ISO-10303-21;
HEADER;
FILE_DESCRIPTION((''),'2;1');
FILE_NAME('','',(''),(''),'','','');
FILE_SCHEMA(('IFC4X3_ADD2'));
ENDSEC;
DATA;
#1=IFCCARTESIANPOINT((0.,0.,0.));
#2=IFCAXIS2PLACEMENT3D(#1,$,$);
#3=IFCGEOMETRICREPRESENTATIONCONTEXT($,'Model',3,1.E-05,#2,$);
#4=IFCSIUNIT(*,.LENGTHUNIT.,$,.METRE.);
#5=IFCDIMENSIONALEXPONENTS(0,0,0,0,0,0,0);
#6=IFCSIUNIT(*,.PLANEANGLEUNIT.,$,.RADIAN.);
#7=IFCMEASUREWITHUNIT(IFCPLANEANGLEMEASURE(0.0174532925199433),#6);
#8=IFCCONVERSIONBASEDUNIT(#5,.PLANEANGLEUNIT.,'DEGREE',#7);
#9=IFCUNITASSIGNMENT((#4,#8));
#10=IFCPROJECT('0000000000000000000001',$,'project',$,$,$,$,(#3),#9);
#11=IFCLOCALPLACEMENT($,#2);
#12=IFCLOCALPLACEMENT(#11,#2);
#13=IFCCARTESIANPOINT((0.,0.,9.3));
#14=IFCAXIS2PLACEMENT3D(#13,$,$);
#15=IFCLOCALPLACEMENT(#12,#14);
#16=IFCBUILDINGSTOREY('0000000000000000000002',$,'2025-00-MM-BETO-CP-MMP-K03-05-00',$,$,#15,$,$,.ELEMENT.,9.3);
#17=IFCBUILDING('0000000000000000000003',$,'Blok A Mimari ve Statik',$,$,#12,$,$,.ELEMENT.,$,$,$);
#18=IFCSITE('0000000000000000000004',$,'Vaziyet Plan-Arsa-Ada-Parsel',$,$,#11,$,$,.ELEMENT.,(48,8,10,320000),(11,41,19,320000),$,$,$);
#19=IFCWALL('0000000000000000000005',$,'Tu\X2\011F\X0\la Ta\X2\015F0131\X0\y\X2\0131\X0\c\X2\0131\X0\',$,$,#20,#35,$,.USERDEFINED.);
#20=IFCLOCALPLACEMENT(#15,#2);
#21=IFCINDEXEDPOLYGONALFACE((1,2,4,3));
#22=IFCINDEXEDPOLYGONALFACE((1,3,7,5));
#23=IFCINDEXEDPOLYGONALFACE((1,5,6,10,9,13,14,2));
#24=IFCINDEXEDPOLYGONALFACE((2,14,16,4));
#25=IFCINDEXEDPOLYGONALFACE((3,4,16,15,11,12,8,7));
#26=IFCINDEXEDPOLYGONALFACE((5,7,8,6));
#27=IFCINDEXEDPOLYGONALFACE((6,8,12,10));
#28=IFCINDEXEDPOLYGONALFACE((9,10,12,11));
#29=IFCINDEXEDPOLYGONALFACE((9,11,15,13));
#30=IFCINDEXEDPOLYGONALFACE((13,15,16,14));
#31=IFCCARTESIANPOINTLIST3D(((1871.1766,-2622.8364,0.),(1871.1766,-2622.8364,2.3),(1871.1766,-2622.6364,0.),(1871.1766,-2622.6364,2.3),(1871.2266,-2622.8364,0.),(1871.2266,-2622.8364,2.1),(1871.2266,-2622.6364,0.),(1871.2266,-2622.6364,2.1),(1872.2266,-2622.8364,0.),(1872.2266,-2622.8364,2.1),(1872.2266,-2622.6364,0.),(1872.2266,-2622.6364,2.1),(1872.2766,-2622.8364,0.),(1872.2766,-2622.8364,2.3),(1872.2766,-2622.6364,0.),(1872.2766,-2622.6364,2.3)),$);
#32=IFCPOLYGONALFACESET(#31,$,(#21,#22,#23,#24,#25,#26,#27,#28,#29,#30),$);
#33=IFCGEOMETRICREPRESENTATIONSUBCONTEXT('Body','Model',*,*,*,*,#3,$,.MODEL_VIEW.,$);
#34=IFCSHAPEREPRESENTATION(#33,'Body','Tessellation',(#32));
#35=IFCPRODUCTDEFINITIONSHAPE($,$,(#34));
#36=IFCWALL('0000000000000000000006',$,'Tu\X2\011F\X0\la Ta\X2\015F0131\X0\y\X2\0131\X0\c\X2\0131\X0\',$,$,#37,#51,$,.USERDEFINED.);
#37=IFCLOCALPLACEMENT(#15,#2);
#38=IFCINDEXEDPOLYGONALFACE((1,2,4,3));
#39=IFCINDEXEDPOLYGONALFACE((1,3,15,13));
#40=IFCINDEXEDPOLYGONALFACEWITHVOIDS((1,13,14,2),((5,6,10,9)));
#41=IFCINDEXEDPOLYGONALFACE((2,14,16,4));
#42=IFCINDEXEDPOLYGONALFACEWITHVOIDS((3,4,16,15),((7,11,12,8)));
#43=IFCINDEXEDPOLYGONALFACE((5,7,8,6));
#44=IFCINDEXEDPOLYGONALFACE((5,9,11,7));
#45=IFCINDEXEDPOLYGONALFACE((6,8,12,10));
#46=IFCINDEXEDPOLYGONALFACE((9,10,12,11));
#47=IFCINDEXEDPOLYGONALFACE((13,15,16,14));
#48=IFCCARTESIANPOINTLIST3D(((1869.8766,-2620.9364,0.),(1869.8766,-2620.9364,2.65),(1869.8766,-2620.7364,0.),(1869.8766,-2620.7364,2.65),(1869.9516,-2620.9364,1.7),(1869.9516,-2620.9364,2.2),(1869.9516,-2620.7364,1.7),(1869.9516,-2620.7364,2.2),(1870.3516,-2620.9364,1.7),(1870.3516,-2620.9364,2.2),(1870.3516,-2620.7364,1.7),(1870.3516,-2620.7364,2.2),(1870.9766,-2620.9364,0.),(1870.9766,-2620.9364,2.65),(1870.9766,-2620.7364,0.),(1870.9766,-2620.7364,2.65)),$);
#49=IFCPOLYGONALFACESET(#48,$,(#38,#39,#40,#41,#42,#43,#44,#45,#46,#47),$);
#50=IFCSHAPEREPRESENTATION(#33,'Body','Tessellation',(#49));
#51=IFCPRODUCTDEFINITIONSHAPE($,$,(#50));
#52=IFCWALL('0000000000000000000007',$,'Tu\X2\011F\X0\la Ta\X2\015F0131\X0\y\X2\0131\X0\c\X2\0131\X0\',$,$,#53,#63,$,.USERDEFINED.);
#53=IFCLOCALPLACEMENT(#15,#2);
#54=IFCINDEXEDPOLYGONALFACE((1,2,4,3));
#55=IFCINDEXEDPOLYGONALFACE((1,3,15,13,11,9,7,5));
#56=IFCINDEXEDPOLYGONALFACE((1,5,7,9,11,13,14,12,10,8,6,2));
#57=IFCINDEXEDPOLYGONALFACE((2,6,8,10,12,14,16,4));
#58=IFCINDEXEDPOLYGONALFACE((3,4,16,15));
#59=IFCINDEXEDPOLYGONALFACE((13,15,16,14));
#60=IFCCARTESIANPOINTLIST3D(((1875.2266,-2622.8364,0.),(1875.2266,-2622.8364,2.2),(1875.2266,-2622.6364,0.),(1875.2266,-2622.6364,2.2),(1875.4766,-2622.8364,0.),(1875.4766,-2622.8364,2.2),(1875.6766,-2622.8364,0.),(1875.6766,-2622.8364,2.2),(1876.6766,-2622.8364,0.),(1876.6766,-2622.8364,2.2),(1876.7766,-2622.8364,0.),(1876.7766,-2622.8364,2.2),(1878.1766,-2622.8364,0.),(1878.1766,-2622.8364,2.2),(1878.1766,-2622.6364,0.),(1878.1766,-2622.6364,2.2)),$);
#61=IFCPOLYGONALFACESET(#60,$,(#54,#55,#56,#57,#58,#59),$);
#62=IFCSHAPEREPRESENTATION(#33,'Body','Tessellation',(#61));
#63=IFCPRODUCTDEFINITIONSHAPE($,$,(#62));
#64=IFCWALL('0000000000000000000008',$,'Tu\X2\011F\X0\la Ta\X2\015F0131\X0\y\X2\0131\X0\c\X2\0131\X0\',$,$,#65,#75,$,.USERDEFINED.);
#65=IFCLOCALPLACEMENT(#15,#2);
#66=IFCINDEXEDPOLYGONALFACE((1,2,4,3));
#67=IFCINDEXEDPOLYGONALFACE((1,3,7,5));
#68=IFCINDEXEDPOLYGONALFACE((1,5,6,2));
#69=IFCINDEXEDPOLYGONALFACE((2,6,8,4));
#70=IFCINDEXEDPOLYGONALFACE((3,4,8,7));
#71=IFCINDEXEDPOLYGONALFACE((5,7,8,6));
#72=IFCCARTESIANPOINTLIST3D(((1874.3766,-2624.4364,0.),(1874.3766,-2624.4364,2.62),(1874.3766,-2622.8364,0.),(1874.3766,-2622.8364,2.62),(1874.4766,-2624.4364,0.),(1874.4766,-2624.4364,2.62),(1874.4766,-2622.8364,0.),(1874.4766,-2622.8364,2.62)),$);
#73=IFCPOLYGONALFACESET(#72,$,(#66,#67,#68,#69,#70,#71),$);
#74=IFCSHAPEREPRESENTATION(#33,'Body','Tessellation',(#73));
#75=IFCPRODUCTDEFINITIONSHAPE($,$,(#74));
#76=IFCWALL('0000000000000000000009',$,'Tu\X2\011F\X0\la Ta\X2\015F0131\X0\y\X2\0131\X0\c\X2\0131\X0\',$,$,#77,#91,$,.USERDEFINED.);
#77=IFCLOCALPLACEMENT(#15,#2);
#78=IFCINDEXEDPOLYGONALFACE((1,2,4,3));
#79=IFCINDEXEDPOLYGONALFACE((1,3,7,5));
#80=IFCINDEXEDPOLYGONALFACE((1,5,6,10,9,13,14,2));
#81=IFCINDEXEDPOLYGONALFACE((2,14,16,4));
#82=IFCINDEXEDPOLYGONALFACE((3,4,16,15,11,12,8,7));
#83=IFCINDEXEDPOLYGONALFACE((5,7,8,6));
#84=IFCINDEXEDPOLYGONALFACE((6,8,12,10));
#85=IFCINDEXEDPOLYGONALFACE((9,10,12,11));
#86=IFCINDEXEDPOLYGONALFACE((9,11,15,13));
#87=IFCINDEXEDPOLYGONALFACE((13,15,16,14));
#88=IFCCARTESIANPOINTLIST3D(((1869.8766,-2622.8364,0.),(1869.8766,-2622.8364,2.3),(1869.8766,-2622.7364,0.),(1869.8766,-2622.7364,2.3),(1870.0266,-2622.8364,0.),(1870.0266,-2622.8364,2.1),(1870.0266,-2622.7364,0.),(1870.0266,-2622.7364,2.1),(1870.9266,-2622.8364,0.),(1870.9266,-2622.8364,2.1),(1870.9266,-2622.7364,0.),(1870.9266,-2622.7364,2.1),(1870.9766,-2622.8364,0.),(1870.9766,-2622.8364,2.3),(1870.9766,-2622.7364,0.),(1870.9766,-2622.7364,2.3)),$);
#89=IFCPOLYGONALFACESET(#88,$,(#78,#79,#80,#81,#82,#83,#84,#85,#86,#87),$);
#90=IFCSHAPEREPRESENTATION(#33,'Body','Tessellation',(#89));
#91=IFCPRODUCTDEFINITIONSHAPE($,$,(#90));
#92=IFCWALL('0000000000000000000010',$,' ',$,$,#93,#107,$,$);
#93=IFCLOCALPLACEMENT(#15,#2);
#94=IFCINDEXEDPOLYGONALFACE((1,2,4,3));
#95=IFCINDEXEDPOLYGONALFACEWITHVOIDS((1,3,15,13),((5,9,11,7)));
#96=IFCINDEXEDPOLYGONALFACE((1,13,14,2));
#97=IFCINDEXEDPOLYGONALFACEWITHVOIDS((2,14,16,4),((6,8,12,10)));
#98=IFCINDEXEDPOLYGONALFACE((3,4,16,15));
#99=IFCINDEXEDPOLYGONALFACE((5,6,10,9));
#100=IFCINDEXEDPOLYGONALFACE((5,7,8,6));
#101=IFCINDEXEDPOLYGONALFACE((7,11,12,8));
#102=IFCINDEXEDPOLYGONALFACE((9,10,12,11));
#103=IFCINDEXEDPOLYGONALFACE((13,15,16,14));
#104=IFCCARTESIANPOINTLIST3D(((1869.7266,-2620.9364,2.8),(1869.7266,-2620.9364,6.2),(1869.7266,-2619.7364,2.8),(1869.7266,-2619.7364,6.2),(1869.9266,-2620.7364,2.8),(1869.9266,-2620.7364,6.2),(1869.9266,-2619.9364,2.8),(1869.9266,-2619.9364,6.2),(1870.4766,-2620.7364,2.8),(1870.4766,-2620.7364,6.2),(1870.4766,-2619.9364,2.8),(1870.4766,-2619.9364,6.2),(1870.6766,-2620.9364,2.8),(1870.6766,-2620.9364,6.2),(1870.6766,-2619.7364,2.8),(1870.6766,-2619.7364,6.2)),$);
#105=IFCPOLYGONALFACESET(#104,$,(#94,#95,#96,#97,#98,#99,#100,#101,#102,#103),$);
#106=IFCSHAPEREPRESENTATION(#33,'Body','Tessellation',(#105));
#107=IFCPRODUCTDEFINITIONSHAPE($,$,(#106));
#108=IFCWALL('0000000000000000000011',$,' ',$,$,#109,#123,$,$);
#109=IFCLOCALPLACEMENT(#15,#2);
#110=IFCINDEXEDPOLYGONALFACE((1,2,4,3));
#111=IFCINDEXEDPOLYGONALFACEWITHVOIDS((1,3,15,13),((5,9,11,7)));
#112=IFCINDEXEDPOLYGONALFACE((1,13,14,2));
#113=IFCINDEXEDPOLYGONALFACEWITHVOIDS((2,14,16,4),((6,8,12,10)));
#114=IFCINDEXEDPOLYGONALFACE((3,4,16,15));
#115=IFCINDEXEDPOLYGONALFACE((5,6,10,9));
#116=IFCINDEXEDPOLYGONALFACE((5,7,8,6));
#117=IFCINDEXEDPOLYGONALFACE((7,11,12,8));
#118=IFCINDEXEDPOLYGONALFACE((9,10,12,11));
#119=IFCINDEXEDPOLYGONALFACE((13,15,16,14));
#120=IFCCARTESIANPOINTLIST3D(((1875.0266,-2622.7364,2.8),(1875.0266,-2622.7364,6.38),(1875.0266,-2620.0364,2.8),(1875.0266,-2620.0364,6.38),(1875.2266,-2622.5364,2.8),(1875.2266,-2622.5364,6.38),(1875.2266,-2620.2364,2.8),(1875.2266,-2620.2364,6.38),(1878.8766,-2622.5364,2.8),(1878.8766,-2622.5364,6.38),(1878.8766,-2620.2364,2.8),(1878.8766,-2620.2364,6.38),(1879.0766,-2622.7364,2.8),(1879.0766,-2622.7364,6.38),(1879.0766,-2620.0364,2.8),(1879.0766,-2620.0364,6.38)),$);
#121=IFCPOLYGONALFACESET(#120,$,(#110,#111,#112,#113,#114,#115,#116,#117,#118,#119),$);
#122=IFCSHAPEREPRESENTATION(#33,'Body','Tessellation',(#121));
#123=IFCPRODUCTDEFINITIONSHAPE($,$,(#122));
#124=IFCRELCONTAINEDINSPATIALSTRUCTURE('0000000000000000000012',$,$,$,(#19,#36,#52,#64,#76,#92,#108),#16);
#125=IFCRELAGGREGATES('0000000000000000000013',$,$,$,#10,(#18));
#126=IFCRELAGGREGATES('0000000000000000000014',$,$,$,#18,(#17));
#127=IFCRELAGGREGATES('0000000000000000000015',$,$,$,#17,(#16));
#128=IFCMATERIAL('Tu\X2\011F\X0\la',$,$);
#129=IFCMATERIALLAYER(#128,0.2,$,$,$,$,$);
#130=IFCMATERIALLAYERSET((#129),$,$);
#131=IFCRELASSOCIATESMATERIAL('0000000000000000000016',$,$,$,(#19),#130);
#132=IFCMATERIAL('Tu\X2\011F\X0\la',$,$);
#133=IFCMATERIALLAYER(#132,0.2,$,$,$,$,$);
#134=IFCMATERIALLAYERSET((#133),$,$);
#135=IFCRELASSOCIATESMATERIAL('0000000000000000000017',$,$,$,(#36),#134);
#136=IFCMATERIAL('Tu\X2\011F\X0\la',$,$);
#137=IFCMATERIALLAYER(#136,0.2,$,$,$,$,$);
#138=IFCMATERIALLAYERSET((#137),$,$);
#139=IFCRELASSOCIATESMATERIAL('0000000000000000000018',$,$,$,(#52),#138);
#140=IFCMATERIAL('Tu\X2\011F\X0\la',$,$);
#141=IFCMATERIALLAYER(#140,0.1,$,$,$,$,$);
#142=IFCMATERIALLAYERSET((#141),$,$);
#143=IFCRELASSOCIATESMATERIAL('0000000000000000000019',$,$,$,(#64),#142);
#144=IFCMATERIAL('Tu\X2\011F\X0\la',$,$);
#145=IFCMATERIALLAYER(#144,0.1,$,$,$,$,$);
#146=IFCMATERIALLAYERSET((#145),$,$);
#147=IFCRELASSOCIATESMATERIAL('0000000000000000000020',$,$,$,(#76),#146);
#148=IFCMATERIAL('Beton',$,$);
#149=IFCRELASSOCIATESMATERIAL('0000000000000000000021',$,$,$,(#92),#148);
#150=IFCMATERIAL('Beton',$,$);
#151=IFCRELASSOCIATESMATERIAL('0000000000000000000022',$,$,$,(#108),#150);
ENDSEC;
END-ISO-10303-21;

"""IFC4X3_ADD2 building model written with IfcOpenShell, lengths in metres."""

from ifc_helpers import new_model, entity, si_unit, converted_unit, frame, frame_2d, origin, origin_with_axes, place, context, subcontext, project, spatial, polyline, rectangle, outline, extrude, material, layer, layer_set, layer_usage, element, save


model = new_model("IFC4X3_ADD2")

# Units and contexts
model_context = context("Model", 3, precision=1e-05, world=origin())
body_context = subcontext(model_context, "Body", "Model", "MODEL_VIEW")
ifc_project = project(units=[si_unit("LENGTHUNIT", "METRE"), converted_unit("PLANEANGLEUNIT", "DEGREE", entity("IfcPlaneAngleMeasure", 0.0174532925199433), si_unit("PLANEANGLEUNIT", "RADIAN"), dimensions=[0, 0, 0, 0, 0, 0, 0])], contexts=[model_context])

# Site, building, storey
site_placement = place(None, origin())
site = spatial("IfcSite", under=ifc_project, at=site_placement, Name="Vaziyet Plan-Arsa-Ada-Parsel", CompositionType="ELEMENT", RefLatitude=(48, 8, 10, 320000), RefLongitude=(11, 41, 19, 320000))
building_placement = place(site_placement, origin())
building = spatial("IfcBuilding", under=site, at=building_placement, Name="Blok A Mimari ve Statik", CompositionType="ELEMENT")
storey_placement = place(building_placement, frame((0.0, 0.0, 9.3)))
storey = spatial("IfcBuildingStorey", under=building, at=storey_placement, Name="2025-00-MM-BETO-CP-MMP-K03-05-00", CompositionType="ELEMENT", Elevation=9.3)

# Walls, openings
ifc_material_1 = material(Name="Tuğla")
ifc_layer_1 = layer(ifc_material_1, 0.2)
ifc_layer_set_1 = layer_set([ifc_layer_1])
ifc_layer_usage_1 = layer_usage(ifc_layer_set_1, "AXIS2", "POSITIVE", 0.0)
wall_1_placement = place(storey_placement, frame((1872.2766, -2622.6364, 0.0), z_axis=(0.0, 0.0, 1.0), x_axis=(-1.0, 0.0, 0.0)))
wall_1 = element("IfcWall", 1, at=wall_1_placement, inside=storey, material=ifc_layer_usage_1, Name="Tuğla Taşıyıcı", PredefinedType="USERDEFINED", context=body_context, shape_type="SweptSolid", body=[
    extrude(rectangle(XDim=1.1, YDim=0.2, at=frame_2d((0.55, 0.1), x_axis=(1.0, 0.0))), origin_with_axes(), (0.0, 0.0, 1.0), 2.3),
])
opening_1_placement = place(wall_1_placement, frame((1.05, 0.2, 0.0), z_axis=(0.0, -1.0, 0.0), x_axis=(0.0, 0.0, 1.0)))
element("IfcOpeningElement", 2, at=opening_1_placement, cuts=wall_1, PredefinedType="OPENING", context=body_context, shape_type="SweptSolid", body=[
    extrude(outline(polyline([(2.1, 1.0), (2.1, 0.0), (0.0, 0.0), (0.0, 1.0), (2.1, 1.0)])), origin_with_axes(), (0.0, 0.0, 1.0), 0.2),
])
ifc_material_2 = material(Name="Tuğla")
ifc_layer_2 = layer(ifc_material_2, 0.2)
ifc_layer_set_2 = layer_set([ifc_layer_2])
ifc_layer_usage_2 = layer_usage(ifc_layer_set_2, "AXIS2", "POSITIVE", 0.0)
wall_2_placement = place(storey_placement, frame((1870.9766, -2620.7364, 0.0), z_axis=(0.0, 0.0, 1.0), x_axis=(-1.0, 0.0, 0.0)))
wall_2 = element("IfcWall", 3, at=wall_2_placement, inside=storey, material=ifc_layer_usage_2, Name="Tuğla Taşıyıcı", PredefinedType="USERDEFINED", context=body_context, shape_type="SweptSolid", body=[
    extrude(rectangle(XDim=1.1, YDim=0.2, at=frame_2d((0.55, 0.1), x_axis=(1.0, 0.0))), origin_with_axes(), (0.0, 0.0, 1.0), 2.65),
])
opening_2_placement = place(wall_2_placement, frame((1.025, 0.2, 1.7), z_axis=(0.0, -1.0, 0.0), x_axis=(0.0, 0.0, 1.0)))
element("IfcOpeningElement", 4, at=opening_2_placement, cuts=wall_2, PredefinedType="OPENING", context=body_context, shape_type="SweptSolid", body=[
    extrude(outline(polyline([(0.5, 0.4), (0.5, 0.0), (0.0, 0.0), (0.0, 0.4), (0.5, 0.4)])), origin_with_axes(), (0.0, 0.0, 1.0), 0.2),
])

# Walls
ifc_material_3 = material(Name="Tuğla")
ifc_layer_3 = layer(ifc_material_3, 0.2)
ifc_layer_set_3 = layer_set([ifc_layer_3])
ifc_layer_usage_3 = layer_usage(ifc_layer_set_3, "AXIS2", "POSITIVE", 0.0)
wall_3_placement = place(storey_placement, frame((1875.2266, -2622.8364, 0.0)))
element("IfcWall", 5, at=wall_3_placement, inside=storey, material=ifc_layer_usage_3, Name="Tuğla Taşıyıcı", PredefinedType="USERDEFINED", context=body_context, shape_type="SweptSolid", body=[
    extrude(outline(polyline([(1.55, 0.0), (2.95, 0.0), (2.95, 0.2), (0.0, 0.2), (0.0, 0.0), (0.25, 0.0), (0.45, 0.0), (1.45, 0.0), (1.55, 0.0)])), origin_with_axes(), (0.0, 0.0, 1.0), 2.2),
])
ifc_material_4 = material(Name="Tuğla")
ifc_layer_4 = layer(ifc_material_4, 0.1)
ifc_layer_set_4 = layer_set([ifc_layer_4])
ifc_layer_usage_4 = layer_usage(ifc_layer_set_4, "AXIS2", "POSITIVE", 0.0)
wall_4_placement = place(storey_placement, frame((1874.4766, -2624.4364, 0.0), z_axis=(0.0, 0.0, 1.0), x_axis=(0.0, 1.0, 0.0)))
element("IfcWall", 6, at=wall_4_placement, inside=storey, material=ifc_layer_usage_4, Name="Tuğla Taşıyıcı", PredefinedType="USERDEFINED", context=body_context, shape_type="SweptSolid", body=[
    extrude(rectangle(XDim=1.6, YDim=0.1, at=frame_2d((0.8, 0.05), x_axis=(1.0, 0.0))), origin_with_axes(), (0.0, 0.0, 1.0), 2.62),
])

# Wall, opening
ifc_material_5 = material(Name="Tuğla")
ifc_layer_5 = layer(ifc_material_5, 0.1)
ifc_layer_set_5 = layer_set([ifc_layer_5])
ifc_layer_usage_5 = layer_usage(ifc_layer_set_5, "AXIS2", "POSITIVE", 0.0)
wall_5_placement = place(storey_placement, frame((1869.8766, -2622.8364, 0.0), z_axis=(0.0, 0.0, 1.0), x_axis=(1.0, 0.000001, 0.0)))
wall_5 = element("IfcWall", 7, at=wall_5_placement, inside=storey, material=ifc_layer_usage_5, Name="Tuğla Taşıyıcı", PredefinedType="USERDEFINED", context=body_context, shape_type="SweptSolid", body=[
    extrude(rectangle(XDim=1.1, YDim=0.1, at=frame_2d((0.55, 0.05), x_axis=(1.0, 0.0))), origin_with_axes(), (0.0, 0.0, 1.0), 2.3),
])
opening_3_placement = place(wall_5_placement, frame((0.15, 0.0, 0.0), z_axis=(0.0, 1.0, 0.0), x_axis=(0.0, 0.0, 1.0)))
element("IfcOpeningElement", 8, at=opening_3_placement, cuts=wall_5, PredefinedType="OPENING", context=body_context, shape_type="SweptSolid", body=[
    extrude(outline(polyline([(2.1, 0.9), (2.1, 0.0), (0.0, 0.0), (0.0, 0.9), (2.1, 0.9)])), origin_with_axes(), (0.0, 0.0, 1.0), 0.1),
])

# Walls
ifc_material_6 = material(Name="Beton")
wall_6_placement = place(storey_placement, frame((1869.7266, -2620.9364, 2.8)))
element("IfcWall", 9, at=wall_6_placement, inside=storey, material=ifc_material_6, Name=" ", context=body_context, shape_type="SweptSolid", body=[
    extrude(outline(polyline([(0.0, 0.0), (0.95, 0.0), (0.95, 1.2), (0.0, 1.2), (0.0, 0.0)]), holes=[polyline([(0.2, 0.2), (0.2, 1.0), (0.75, 1.0), (0.75, 0.2), (0.2, 0.2)])]), origin_with_axes(), (0.0, 0.0, 1.0), 3.4),
])
ifc_material_7 = material(Name="Beton")
wall_7_placement = place(storey_placement, frame((1875.0266, -2622.7364, 2.8)))
element("IfcWall", 10, at=wall_7_placement, inside=storey, material=ifc_material_7, Name=" ", context=body_context, shape_type="SweptSolid", body=[
    extrude(outline(polyline([(0.0, 0.0), (4.05, 0.0), (4.05, 2.7), (0.0, 2.7), (0.0, 0.0)]), holes=[polyline([(0.2, 0.2), (0.2, 2.5), (3.85, 2.5), (3.85, 0.2), (0.2, 0.2)])]), origin_with_axes(), (0.0, 0.0, 1.0), 3.58),
])

save(model, "model.ifc")
